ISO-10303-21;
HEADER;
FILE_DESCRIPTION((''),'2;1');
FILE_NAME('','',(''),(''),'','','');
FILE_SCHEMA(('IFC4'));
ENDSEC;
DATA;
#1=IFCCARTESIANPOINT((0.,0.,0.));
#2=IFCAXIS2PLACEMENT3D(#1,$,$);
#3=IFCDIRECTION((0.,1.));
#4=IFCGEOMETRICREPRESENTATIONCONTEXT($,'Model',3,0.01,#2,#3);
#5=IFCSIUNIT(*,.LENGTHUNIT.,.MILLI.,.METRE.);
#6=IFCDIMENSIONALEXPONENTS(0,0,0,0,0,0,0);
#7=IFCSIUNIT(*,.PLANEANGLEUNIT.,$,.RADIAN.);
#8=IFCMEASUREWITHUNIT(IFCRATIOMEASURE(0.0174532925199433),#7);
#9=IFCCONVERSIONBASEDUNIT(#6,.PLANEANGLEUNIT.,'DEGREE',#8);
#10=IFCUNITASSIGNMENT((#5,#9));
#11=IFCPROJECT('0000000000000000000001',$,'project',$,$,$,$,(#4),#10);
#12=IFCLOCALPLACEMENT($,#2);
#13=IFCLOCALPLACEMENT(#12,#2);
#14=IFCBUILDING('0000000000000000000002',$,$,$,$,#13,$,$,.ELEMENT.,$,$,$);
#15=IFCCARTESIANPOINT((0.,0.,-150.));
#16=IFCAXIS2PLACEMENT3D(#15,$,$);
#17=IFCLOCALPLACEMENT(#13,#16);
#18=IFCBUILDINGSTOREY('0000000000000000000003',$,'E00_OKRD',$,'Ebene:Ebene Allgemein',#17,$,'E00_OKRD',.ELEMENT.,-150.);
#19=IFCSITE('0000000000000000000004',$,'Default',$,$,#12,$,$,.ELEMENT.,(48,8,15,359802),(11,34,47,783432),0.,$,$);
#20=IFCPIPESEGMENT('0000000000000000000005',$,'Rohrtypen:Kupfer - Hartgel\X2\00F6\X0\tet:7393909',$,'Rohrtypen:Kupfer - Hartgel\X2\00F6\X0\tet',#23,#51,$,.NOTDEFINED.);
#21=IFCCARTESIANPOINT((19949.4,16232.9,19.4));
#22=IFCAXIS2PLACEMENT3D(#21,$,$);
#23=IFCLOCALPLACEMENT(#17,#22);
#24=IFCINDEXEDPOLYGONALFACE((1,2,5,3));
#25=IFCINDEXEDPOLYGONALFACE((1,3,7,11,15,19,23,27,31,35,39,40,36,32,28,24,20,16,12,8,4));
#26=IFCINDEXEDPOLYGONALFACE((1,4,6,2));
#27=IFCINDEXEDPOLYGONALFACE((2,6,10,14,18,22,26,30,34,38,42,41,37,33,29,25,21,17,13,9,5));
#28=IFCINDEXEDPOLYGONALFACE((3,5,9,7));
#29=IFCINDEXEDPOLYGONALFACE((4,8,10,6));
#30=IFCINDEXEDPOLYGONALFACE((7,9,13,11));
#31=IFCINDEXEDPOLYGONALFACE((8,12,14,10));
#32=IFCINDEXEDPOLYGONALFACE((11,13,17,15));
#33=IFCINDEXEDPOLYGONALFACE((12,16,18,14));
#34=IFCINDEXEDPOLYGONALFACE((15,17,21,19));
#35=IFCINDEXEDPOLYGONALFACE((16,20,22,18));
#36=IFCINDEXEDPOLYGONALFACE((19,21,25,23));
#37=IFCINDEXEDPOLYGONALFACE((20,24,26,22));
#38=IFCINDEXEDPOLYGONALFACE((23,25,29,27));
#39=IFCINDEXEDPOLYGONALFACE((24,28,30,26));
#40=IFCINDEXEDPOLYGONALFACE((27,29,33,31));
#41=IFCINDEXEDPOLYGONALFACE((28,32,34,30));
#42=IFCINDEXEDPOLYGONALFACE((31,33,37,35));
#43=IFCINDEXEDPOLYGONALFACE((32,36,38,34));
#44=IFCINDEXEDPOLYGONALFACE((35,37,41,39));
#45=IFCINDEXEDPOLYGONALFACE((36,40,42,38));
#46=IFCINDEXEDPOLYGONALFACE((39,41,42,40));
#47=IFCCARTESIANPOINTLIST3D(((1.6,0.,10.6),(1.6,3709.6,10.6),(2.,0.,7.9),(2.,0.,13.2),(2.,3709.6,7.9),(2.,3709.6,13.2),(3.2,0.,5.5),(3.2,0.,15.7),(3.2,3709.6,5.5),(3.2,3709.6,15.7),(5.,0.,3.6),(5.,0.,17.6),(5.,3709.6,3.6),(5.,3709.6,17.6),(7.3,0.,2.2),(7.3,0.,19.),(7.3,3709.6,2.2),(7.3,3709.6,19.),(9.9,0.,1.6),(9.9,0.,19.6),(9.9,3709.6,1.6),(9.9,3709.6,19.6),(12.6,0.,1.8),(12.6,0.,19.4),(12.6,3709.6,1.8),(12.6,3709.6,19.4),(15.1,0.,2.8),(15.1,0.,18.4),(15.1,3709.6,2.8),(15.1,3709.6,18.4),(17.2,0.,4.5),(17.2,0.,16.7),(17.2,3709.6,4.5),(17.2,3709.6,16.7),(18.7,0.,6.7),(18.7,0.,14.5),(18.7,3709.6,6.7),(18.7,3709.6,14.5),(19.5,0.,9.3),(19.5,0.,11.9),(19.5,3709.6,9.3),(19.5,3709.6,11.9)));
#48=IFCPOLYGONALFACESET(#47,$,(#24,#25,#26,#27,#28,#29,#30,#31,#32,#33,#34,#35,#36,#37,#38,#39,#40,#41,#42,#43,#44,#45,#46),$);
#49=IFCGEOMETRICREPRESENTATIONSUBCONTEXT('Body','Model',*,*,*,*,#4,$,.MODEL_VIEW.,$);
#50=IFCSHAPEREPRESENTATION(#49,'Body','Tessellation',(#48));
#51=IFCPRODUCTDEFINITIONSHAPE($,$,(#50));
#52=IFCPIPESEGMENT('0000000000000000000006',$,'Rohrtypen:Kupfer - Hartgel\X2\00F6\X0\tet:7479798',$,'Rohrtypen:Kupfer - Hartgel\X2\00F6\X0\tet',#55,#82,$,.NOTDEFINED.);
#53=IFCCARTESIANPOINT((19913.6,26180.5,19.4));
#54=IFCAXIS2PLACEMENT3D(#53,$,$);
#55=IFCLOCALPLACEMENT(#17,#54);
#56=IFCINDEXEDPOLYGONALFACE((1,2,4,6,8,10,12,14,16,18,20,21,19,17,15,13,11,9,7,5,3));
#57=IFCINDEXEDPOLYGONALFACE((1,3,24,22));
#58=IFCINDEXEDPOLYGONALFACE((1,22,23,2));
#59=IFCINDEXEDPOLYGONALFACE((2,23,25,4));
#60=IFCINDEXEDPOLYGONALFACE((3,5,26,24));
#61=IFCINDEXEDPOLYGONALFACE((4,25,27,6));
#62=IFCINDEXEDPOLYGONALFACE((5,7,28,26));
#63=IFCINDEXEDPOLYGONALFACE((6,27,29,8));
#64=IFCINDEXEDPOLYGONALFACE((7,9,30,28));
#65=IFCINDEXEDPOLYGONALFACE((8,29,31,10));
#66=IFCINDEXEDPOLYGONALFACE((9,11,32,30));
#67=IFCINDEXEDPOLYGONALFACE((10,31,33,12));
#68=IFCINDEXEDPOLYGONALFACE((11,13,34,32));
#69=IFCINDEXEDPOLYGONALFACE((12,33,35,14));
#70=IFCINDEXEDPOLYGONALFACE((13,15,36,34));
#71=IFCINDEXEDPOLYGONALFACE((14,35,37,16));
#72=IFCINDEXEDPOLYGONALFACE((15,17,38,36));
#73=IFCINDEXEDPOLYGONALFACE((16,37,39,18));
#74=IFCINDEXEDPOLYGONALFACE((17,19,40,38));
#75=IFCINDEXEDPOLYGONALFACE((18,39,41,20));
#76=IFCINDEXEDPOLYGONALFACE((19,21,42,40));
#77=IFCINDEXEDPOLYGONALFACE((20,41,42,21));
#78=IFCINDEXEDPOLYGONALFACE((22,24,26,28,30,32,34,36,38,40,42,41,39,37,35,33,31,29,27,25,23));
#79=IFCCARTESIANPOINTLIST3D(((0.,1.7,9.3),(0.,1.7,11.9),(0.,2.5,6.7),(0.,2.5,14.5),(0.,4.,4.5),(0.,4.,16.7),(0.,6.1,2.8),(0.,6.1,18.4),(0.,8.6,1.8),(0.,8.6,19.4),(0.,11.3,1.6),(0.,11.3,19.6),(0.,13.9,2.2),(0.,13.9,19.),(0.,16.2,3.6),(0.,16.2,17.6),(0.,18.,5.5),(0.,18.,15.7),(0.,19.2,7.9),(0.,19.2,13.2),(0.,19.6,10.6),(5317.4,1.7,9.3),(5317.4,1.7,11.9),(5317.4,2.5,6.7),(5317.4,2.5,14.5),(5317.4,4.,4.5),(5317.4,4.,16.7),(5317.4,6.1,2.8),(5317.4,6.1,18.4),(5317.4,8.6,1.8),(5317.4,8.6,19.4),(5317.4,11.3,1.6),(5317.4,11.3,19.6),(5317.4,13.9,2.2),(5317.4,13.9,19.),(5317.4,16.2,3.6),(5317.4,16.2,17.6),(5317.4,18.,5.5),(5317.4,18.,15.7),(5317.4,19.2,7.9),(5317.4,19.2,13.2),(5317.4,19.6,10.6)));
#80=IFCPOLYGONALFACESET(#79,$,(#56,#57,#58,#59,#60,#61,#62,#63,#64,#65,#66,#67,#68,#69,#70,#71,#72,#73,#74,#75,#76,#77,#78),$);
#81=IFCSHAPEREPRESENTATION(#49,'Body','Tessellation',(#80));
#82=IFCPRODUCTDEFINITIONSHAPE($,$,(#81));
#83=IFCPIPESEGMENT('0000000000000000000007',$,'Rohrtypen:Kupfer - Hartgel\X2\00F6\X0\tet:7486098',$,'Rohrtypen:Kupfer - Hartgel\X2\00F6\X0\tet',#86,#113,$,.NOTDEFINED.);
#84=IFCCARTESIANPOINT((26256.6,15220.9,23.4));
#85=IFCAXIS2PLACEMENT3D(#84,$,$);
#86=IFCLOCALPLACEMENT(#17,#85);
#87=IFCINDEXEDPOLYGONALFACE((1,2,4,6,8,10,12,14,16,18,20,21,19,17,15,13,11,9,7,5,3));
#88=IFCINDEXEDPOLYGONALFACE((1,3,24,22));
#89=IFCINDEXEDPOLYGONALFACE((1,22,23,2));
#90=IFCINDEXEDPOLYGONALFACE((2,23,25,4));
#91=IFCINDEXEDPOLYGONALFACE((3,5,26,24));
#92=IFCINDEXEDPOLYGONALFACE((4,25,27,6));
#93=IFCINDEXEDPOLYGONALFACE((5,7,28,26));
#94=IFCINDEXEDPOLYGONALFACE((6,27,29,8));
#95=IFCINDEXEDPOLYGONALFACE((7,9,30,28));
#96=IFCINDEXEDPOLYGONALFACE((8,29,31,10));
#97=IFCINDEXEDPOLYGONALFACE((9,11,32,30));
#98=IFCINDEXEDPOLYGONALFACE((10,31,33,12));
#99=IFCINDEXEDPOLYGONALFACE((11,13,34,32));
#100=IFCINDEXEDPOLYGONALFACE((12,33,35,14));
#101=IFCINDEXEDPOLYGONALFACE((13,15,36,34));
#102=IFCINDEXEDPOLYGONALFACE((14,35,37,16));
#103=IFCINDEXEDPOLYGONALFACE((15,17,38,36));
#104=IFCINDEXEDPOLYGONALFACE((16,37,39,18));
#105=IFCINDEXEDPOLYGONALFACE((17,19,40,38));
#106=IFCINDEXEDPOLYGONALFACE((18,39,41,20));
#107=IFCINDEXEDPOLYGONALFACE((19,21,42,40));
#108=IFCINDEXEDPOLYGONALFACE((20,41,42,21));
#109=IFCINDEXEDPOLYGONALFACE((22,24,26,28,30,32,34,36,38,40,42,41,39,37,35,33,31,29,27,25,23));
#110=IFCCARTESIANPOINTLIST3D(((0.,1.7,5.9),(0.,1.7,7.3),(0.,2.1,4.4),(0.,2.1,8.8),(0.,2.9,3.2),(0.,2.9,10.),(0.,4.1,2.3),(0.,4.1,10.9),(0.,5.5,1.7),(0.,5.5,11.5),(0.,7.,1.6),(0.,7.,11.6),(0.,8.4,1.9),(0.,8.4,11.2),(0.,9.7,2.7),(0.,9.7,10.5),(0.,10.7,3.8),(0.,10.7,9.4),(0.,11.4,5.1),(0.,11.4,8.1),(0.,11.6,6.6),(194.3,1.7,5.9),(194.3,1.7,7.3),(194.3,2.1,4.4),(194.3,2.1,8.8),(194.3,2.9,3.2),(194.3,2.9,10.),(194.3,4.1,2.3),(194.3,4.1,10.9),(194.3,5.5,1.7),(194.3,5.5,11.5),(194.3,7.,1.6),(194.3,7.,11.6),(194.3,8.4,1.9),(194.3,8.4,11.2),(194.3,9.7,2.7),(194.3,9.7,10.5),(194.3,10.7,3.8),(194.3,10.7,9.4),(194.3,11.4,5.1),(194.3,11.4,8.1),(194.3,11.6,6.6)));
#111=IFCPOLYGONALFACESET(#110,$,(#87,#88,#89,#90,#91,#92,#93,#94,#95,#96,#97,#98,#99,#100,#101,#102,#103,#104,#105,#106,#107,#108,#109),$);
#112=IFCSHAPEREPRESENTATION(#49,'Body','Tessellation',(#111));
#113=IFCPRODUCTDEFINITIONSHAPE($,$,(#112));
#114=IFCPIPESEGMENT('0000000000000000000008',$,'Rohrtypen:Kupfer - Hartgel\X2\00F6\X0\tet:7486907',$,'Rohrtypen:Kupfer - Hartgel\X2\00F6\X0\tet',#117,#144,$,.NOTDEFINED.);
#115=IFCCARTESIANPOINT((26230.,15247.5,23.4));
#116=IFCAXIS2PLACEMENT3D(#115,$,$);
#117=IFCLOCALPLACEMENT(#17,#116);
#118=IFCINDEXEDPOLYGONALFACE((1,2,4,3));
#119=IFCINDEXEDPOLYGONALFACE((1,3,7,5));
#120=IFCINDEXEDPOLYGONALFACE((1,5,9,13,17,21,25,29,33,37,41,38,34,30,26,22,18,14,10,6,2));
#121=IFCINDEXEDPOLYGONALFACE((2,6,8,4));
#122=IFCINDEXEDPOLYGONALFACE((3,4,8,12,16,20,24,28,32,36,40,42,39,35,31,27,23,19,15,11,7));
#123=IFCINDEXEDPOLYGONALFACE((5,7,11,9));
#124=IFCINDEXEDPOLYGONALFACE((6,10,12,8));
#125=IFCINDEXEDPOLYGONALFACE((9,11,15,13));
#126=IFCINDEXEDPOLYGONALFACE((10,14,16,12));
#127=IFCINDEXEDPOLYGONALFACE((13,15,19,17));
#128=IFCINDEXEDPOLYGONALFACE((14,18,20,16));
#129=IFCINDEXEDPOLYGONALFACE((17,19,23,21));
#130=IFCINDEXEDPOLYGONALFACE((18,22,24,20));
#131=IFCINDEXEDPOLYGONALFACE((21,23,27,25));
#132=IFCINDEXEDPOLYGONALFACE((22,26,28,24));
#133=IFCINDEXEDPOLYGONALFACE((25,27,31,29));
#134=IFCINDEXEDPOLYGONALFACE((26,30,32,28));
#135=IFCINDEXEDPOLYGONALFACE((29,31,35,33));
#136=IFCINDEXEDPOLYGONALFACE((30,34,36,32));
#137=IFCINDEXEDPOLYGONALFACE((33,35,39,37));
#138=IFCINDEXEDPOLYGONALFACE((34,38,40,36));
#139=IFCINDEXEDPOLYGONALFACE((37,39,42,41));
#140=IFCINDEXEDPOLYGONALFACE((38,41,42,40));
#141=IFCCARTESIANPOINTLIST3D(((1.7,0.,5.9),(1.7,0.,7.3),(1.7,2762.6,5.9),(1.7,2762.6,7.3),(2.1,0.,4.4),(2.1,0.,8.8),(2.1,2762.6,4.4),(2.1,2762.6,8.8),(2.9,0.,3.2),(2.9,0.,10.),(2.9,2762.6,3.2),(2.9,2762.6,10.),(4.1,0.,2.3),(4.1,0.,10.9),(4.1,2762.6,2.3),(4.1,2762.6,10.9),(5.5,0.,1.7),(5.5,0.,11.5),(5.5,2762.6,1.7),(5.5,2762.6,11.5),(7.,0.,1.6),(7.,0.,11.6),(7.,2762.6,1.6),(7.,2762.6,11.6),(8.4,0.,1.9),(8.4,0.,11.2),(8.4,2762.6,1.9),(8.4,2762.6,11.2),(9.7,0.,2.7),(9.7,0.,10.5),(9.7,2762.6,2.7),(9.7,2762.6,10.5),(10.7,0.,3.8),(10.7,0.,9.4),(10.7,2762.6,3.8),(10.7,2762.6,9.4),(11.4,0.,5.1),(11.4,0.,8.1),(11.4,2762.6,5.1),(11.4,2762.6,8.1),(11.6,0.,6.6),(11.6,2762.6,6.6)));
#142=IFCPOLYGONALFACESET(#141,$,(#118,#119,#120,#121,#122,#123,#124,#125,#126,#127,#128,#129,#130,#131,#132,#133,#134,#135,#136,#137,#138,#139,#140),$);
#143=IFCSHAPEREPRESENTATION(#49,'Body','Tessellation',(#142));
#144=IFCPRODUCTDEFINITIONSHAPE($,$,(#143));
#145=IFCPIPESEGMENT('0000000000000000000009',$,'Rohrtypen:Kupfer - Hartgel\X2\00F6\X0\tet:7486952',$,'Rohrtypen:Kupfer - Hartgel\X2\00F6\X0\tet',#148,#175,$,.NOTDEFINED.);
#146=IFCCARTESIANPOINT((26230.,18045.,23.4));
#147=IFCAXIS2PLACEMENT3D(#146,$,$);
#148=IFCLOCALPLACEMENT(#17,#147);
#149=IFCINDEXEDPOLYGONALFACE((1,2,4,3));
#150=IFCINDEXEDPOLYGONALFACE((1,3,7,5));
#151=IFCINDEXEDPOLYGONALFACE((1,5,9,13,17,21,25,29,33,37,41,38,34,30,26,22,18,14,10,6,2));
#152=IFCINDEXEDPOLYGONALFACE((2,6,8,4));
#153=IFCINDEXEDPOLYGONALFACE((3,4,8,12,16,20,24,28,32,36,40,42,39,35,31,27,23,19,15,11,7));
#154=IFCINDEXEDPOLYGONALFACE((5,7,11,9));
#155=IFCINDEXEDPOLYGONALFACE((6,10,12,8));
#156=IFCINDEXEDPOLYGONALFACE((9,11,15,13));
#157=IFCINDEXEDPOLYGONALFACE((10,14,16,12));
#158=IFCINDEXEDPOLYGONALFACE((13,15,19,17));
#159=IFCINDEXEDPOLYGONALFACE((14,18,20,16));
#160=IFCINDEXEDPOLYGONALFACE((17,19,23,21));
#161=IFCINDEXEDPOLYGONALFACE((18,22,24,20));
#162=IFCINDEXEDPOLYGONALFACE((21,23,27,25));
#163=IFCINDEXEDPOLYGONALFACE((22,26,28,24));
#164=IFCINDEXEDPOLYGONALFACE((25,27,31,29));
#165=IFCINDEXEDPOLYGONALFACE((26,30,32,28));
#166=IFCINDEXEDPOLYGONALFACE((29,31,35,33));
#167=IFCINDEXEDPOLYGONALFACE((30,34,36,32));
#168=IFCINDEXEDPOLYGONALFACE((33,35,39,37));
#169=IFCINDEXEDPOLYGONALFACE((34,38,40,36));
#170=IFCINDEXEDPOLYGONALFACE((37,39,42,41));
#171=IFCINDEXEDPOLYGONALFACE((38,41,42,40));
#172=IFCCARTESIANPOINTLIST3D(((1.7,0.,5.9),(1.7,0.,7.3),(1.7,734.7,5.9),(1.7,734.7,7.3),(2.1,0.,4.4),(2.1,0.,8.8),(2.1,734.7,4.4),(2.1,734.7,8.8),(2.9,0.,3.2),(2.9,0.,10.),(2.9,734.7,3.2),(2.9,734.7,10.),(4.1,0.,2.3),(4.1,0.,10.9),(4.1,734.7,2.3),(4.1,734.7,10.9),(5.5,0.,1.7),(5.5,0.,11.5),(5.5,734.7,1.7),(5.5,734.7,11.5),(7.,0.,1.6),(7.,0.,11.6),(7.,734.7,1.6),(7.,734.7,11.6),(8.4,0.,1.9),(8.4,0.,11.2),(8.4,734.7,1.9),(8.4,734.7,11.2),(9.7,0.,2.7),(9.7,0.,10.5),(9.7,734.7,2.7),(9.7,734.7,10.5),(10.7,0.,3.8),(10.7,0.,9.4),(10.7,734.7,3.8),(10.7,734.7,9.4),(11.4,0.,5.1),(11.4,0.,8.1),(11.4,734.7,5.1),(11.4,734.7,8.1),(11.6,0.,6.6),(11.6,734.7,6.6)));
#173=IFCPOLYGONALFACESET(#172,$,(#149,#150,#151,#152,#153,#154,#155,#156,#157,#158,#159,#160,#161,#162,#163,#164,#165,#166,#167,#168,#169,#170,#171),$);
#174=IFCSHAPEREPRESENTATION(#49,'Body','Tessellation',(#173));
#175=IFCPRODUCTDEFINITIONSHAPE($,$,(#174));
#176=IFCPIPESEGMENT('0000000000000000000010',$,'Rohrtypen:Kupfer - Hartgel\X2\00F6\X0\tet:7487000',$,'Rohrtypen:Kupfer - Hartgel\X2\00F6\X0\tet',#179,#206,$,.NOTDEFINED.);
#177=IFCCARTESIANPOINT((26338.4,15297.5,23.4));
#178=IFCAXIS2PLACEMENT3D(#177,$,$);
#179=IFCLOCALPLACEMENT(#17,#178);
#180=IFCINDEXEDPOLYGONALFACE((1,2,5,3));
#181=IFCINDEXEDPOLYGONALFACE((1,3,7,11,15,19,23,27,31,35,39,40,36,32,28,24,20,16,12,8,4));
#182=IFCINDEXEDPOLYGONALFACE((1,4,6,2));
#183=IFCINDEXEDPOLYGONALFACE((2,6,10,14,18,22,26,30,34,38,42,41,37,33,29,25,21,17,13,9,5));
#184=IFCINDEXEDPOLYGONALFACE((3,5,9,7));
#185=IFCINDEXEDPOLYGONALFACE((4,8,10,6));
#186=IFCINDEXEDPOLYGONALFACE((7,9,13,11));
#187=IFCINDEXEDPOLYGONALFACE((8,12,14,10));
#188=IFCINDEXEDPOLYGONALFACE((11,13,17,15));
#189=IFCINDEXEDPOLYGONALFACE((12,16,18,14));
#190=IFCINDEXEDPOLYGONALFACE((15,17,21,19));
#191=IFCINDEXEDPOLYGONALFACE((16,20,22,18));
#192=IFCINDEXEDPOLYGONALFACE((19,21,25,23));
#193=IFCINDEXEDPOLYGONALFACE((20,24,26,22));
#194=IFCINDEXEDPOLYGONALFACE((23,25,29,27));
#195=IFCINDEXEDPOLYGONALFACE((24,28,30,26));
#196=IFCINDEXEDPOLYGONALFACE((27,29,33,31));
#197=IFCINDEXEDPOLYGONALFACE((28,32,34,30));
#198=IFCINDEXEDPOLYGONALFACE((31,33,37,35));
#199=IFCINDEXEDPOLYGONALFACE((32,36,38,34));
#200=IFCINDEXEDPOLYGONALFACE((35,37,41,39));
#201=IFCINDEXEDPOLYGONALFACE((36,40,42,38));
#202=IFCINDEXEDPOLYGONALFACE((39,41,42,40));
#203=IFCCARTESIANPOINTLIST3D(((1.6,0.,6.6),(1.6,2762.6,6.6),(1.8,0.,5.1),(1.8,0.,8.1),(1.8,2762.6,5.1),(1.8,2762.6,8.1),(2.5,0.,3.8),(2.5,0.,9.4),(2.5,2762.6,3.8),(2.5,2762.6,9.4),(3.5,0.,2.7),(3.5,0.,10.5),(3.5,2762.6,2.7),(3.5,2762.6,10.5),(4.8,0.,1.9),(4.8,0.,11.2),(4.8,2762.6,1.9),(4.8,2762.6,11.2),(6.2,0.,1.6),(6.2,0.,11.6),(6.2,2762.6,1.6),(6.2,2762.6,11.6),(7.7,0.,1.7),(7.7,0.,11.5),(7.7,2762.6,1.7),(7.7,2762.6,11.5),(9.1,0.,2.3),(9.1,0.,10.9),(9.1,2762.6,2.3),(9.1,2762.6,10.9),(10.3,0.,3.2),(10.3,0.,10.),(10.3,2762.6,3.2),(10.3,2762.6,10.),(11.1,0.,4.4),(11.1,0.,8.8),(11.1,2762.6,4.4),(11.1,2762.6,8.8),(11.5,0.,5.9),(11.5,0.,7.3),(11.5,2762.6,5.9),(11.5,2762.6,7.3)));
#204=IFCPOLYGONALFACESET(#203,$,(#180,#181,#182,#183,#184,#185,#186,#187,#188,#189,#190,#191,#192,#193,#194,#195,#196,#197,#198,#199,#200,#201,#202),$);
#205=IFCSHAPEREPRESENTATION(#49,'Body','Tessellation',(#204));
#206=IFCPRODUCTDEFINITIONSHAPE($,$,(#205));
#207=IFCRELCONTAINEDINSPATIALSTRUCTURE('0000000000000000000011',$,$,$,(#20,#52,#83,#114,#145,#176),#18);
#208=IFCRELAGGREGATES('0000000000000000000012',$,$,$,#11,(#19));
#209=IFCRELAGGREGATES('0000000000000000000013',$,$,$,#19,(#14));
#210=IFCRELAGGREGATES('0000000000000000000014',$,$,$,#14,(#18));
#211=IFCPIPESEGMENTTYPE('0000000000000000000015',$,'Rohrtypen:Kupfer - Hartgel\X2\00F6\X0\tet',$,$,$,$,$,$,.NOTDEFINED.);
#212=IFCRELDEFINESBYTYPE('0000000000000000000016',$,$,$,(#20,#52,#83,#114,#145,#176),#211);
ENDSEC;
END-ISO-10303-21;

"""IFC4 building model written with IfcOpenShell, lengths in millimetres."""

from ifc_helpers import new_model, entity, si_unit, converted_unit, direction, frame, frame_2d, origin, origin_2d_with_axis, place, context, subcontext, project, spatial, circle, extrude, type_object, element, save


model = new_model("IFC4")

# Units and contexts
model_context = context("Model", 3, precision=0.01, world=origin(), true_north=direction((0.0, 1.0)))
body_context = subcontext(model_context, "Body", "Model", "MODEL_VIEW")
ifc_project = project(units=[si_unit("LENGTHUNIT", "METRE", prefix="MILLI"), converted_unit("PLANEANGLEUNIT", "DEGREE", entity("IfcRatioMeasure", 0.0174532925199433), si_unit("PLANEANGLEUNIT", "RADIAN"), dimensions=[0, 0, 0, 0, 0, 0, 0])], contexts=[model_context])

# Site, building, storey
site_placement = place(None, origin())
site = spatial("IfcSite", under=ifc_project, at=site_placement, Name="Default", CompositionType="ELEMENT", RefLatitude=(48, 8, 15, 359802), RefLongitude=(11, 34, 47, 783432), RefElevation=0.0)
building_placement = place(site_placement, origin())
building = spatial("IfcBuilding", under=site, at=building_placement, CompositionType="ELEMENT")
storey_placement = place(building_placement, frame((0.0, 0.0, -150.0)))
storey = spatial("IfcBuildingStorey", under=building, at=storey_placement, Name="E00_OKRD", ObjectType="Ebene:Ebene Allgemein", LongName="E00_OKRD", CompositionType="ELEMENT", Elevation=-150.0)

# Pipe segments
pipe_segment_type = type_object("IfcPipeSegmentType", Name="Rohrtypen:Kupfer - Hartgelötet", PredefinedType="NOTDEFINED")
pipe_segment_1_placement = place(storey_placement, frame((19949.4, 16232.9, 19.4)))
element("IfcPipeSegment", 1, at=pipe_segment_1_placement, inside=storey, type_object=pipe_segment_type, Name="Rohrtypen:Kupfer - Hartgelötet:7393909", ObjectType="Rohrtypen:Kupfer - Hartgelötet", PredefinedType="NOTDEFINED", context=body_context, shape_type="SweptSolid", body=[
    extrude(circle(Radius=9.0, at=frame_2d((0.0, 0.0), x_axis=(1.0, 0.0))), frame((10.6, 0.0, 10.6), z_axis=(0.0, 1.0, 0.0), x_axis=(-1.0, 0.0, 0.0)), (0.0, 0.0, 1.0), 3709.6),
])
pipe_segment_2_placement = place(storey_placement, frame((19913.6, 26180.5, 19.4)))
element("IfcPipeSegment", 2, at=pipe_segment_2_placement, inside=storey, type_object=pipe_segment_type, Name="Rohrtypen:Kupfer - Hartgelötet:7479798", ObjectType="Rohrtypen:Kupfer - Hartgelötet", PredefinedType="NOTDEFINED", context=body_context, shape_type="SweptSolid", body=[
    extrude(circle(Radius=9.0, at=origin_2d_with_axis()), frame((0.0, 10.6, 10.6), z_axis=(1.0, 0.0, 0.0), x_axis=(0.0, 1.0, 0.0)), (0.0, 0.0, 1.0), 5317.4),
])
pipe_segment_3_placement = place(storey_placement, frame((26256.6, 15220.9, 23.4)))
element("IfcPipeSegment", 3, at=pipe_segment_3_placement, inside=storey, type_object=pipe_segment_type, Name="Rohrtypen:Kupfer - Hartgelötet:7486098", ObjectType="Rohrtypen:Kupfer - Hartgelötet", PredefinedType="NOTDEFINED", context=body_context, shape_type="SweptSolid", body=[
    extrude(circle(Radius=5.0, at=frame_2d((0.0, 0.0), x_axis=(1.0, 0.0))), frame((0.0, 6.6, 6.6), z_axis=(1.0, 0.0, 0.0), x_axis=(0.0, 1.0, 0.0)), (0.0, 0.0, 1.0), 194.3),
])
pipe_segment_4_placement = place(storey_placement, frame((26230.0, 15247.5, 23.4)))
element("IfcPipeSegment", 4, at=pipe_segment_4_placement, inside=storey, type_object=pipe_segment_type, Name="Rohrtypen:Kupfer - Hartgelötet:7486907", ObjectType="Rohrtypen:Kupfer - Hartgelötet", PredefinedType="NOTDEFINED", context=body_context, shape_type="SweptSolid", body=[
    extrude(circle(Radius=5.0, at=frame_2d((0.0, 0.0), x_axis=(1.0, 0.0))), frame((6.6, 0.0, 6.6), z_axis=(0.0, 1.0, 0.0), x_axis=(1.0, 0.0, 0.0)), (0.0, 0.0, 1.0), 2762.6),
])
pipe_segment_5_placement = place(storey_placement, frame((26230.0, 18045.0, 23.4)))
element("IfcPipeSegment", 5, at=pipe_segment_5_placement, inside=storey, type_object=pipe_segment_type, Name="Rohrtypen:Kupfer - Hartgelötet:7486952", ObjectType="Rohrtypen:Kupfer - Hartgelötet", PredefinedType="NOTDEFINED", context=body_context, shape_type="SweptSolid", body=[
    extrude(circle(Radius=5.0, at=frame_2d((0.0, 0.0), x_axis=(1.0, 0.0))), frame((6.6, 0.0, 6.6), z_axis=(0.0, 1.0, 0.0), x_axis=(1.0, 0.0, 0.0)), (0.0, 0.0, 1.0), 734.7),
])
pipe_segment_6_placement = place(storey_placement, frame((26338.4, 15297.5, 23.4)))
element("IfcPipeSegment", 6, at=pipe_segment_6_placement, inside=storey, type_object=pipe_segment_type, Name="Rohrtypen:Kupfer - Hartgelötet:7487000", ObjectType="Rohrtypen:Kupfer - Hartgelötet", PredefinedType="NOTDEFINED", context=body_context, shape_type="SweptSolid", body=[
    extrude(circle(Radius=5.0, at=frame_2d((0.0, 0.0), x_axis=(1.0, 0.0))), frame((6.6, 0.0, 6.6), z_axis=(0.0, 1.0, 0.0), x_axis=(-1.0, 0.0, 0.0)), (0.0, 0.0, 1.0), 2762.6),
])

save(model, "model.ifc")
